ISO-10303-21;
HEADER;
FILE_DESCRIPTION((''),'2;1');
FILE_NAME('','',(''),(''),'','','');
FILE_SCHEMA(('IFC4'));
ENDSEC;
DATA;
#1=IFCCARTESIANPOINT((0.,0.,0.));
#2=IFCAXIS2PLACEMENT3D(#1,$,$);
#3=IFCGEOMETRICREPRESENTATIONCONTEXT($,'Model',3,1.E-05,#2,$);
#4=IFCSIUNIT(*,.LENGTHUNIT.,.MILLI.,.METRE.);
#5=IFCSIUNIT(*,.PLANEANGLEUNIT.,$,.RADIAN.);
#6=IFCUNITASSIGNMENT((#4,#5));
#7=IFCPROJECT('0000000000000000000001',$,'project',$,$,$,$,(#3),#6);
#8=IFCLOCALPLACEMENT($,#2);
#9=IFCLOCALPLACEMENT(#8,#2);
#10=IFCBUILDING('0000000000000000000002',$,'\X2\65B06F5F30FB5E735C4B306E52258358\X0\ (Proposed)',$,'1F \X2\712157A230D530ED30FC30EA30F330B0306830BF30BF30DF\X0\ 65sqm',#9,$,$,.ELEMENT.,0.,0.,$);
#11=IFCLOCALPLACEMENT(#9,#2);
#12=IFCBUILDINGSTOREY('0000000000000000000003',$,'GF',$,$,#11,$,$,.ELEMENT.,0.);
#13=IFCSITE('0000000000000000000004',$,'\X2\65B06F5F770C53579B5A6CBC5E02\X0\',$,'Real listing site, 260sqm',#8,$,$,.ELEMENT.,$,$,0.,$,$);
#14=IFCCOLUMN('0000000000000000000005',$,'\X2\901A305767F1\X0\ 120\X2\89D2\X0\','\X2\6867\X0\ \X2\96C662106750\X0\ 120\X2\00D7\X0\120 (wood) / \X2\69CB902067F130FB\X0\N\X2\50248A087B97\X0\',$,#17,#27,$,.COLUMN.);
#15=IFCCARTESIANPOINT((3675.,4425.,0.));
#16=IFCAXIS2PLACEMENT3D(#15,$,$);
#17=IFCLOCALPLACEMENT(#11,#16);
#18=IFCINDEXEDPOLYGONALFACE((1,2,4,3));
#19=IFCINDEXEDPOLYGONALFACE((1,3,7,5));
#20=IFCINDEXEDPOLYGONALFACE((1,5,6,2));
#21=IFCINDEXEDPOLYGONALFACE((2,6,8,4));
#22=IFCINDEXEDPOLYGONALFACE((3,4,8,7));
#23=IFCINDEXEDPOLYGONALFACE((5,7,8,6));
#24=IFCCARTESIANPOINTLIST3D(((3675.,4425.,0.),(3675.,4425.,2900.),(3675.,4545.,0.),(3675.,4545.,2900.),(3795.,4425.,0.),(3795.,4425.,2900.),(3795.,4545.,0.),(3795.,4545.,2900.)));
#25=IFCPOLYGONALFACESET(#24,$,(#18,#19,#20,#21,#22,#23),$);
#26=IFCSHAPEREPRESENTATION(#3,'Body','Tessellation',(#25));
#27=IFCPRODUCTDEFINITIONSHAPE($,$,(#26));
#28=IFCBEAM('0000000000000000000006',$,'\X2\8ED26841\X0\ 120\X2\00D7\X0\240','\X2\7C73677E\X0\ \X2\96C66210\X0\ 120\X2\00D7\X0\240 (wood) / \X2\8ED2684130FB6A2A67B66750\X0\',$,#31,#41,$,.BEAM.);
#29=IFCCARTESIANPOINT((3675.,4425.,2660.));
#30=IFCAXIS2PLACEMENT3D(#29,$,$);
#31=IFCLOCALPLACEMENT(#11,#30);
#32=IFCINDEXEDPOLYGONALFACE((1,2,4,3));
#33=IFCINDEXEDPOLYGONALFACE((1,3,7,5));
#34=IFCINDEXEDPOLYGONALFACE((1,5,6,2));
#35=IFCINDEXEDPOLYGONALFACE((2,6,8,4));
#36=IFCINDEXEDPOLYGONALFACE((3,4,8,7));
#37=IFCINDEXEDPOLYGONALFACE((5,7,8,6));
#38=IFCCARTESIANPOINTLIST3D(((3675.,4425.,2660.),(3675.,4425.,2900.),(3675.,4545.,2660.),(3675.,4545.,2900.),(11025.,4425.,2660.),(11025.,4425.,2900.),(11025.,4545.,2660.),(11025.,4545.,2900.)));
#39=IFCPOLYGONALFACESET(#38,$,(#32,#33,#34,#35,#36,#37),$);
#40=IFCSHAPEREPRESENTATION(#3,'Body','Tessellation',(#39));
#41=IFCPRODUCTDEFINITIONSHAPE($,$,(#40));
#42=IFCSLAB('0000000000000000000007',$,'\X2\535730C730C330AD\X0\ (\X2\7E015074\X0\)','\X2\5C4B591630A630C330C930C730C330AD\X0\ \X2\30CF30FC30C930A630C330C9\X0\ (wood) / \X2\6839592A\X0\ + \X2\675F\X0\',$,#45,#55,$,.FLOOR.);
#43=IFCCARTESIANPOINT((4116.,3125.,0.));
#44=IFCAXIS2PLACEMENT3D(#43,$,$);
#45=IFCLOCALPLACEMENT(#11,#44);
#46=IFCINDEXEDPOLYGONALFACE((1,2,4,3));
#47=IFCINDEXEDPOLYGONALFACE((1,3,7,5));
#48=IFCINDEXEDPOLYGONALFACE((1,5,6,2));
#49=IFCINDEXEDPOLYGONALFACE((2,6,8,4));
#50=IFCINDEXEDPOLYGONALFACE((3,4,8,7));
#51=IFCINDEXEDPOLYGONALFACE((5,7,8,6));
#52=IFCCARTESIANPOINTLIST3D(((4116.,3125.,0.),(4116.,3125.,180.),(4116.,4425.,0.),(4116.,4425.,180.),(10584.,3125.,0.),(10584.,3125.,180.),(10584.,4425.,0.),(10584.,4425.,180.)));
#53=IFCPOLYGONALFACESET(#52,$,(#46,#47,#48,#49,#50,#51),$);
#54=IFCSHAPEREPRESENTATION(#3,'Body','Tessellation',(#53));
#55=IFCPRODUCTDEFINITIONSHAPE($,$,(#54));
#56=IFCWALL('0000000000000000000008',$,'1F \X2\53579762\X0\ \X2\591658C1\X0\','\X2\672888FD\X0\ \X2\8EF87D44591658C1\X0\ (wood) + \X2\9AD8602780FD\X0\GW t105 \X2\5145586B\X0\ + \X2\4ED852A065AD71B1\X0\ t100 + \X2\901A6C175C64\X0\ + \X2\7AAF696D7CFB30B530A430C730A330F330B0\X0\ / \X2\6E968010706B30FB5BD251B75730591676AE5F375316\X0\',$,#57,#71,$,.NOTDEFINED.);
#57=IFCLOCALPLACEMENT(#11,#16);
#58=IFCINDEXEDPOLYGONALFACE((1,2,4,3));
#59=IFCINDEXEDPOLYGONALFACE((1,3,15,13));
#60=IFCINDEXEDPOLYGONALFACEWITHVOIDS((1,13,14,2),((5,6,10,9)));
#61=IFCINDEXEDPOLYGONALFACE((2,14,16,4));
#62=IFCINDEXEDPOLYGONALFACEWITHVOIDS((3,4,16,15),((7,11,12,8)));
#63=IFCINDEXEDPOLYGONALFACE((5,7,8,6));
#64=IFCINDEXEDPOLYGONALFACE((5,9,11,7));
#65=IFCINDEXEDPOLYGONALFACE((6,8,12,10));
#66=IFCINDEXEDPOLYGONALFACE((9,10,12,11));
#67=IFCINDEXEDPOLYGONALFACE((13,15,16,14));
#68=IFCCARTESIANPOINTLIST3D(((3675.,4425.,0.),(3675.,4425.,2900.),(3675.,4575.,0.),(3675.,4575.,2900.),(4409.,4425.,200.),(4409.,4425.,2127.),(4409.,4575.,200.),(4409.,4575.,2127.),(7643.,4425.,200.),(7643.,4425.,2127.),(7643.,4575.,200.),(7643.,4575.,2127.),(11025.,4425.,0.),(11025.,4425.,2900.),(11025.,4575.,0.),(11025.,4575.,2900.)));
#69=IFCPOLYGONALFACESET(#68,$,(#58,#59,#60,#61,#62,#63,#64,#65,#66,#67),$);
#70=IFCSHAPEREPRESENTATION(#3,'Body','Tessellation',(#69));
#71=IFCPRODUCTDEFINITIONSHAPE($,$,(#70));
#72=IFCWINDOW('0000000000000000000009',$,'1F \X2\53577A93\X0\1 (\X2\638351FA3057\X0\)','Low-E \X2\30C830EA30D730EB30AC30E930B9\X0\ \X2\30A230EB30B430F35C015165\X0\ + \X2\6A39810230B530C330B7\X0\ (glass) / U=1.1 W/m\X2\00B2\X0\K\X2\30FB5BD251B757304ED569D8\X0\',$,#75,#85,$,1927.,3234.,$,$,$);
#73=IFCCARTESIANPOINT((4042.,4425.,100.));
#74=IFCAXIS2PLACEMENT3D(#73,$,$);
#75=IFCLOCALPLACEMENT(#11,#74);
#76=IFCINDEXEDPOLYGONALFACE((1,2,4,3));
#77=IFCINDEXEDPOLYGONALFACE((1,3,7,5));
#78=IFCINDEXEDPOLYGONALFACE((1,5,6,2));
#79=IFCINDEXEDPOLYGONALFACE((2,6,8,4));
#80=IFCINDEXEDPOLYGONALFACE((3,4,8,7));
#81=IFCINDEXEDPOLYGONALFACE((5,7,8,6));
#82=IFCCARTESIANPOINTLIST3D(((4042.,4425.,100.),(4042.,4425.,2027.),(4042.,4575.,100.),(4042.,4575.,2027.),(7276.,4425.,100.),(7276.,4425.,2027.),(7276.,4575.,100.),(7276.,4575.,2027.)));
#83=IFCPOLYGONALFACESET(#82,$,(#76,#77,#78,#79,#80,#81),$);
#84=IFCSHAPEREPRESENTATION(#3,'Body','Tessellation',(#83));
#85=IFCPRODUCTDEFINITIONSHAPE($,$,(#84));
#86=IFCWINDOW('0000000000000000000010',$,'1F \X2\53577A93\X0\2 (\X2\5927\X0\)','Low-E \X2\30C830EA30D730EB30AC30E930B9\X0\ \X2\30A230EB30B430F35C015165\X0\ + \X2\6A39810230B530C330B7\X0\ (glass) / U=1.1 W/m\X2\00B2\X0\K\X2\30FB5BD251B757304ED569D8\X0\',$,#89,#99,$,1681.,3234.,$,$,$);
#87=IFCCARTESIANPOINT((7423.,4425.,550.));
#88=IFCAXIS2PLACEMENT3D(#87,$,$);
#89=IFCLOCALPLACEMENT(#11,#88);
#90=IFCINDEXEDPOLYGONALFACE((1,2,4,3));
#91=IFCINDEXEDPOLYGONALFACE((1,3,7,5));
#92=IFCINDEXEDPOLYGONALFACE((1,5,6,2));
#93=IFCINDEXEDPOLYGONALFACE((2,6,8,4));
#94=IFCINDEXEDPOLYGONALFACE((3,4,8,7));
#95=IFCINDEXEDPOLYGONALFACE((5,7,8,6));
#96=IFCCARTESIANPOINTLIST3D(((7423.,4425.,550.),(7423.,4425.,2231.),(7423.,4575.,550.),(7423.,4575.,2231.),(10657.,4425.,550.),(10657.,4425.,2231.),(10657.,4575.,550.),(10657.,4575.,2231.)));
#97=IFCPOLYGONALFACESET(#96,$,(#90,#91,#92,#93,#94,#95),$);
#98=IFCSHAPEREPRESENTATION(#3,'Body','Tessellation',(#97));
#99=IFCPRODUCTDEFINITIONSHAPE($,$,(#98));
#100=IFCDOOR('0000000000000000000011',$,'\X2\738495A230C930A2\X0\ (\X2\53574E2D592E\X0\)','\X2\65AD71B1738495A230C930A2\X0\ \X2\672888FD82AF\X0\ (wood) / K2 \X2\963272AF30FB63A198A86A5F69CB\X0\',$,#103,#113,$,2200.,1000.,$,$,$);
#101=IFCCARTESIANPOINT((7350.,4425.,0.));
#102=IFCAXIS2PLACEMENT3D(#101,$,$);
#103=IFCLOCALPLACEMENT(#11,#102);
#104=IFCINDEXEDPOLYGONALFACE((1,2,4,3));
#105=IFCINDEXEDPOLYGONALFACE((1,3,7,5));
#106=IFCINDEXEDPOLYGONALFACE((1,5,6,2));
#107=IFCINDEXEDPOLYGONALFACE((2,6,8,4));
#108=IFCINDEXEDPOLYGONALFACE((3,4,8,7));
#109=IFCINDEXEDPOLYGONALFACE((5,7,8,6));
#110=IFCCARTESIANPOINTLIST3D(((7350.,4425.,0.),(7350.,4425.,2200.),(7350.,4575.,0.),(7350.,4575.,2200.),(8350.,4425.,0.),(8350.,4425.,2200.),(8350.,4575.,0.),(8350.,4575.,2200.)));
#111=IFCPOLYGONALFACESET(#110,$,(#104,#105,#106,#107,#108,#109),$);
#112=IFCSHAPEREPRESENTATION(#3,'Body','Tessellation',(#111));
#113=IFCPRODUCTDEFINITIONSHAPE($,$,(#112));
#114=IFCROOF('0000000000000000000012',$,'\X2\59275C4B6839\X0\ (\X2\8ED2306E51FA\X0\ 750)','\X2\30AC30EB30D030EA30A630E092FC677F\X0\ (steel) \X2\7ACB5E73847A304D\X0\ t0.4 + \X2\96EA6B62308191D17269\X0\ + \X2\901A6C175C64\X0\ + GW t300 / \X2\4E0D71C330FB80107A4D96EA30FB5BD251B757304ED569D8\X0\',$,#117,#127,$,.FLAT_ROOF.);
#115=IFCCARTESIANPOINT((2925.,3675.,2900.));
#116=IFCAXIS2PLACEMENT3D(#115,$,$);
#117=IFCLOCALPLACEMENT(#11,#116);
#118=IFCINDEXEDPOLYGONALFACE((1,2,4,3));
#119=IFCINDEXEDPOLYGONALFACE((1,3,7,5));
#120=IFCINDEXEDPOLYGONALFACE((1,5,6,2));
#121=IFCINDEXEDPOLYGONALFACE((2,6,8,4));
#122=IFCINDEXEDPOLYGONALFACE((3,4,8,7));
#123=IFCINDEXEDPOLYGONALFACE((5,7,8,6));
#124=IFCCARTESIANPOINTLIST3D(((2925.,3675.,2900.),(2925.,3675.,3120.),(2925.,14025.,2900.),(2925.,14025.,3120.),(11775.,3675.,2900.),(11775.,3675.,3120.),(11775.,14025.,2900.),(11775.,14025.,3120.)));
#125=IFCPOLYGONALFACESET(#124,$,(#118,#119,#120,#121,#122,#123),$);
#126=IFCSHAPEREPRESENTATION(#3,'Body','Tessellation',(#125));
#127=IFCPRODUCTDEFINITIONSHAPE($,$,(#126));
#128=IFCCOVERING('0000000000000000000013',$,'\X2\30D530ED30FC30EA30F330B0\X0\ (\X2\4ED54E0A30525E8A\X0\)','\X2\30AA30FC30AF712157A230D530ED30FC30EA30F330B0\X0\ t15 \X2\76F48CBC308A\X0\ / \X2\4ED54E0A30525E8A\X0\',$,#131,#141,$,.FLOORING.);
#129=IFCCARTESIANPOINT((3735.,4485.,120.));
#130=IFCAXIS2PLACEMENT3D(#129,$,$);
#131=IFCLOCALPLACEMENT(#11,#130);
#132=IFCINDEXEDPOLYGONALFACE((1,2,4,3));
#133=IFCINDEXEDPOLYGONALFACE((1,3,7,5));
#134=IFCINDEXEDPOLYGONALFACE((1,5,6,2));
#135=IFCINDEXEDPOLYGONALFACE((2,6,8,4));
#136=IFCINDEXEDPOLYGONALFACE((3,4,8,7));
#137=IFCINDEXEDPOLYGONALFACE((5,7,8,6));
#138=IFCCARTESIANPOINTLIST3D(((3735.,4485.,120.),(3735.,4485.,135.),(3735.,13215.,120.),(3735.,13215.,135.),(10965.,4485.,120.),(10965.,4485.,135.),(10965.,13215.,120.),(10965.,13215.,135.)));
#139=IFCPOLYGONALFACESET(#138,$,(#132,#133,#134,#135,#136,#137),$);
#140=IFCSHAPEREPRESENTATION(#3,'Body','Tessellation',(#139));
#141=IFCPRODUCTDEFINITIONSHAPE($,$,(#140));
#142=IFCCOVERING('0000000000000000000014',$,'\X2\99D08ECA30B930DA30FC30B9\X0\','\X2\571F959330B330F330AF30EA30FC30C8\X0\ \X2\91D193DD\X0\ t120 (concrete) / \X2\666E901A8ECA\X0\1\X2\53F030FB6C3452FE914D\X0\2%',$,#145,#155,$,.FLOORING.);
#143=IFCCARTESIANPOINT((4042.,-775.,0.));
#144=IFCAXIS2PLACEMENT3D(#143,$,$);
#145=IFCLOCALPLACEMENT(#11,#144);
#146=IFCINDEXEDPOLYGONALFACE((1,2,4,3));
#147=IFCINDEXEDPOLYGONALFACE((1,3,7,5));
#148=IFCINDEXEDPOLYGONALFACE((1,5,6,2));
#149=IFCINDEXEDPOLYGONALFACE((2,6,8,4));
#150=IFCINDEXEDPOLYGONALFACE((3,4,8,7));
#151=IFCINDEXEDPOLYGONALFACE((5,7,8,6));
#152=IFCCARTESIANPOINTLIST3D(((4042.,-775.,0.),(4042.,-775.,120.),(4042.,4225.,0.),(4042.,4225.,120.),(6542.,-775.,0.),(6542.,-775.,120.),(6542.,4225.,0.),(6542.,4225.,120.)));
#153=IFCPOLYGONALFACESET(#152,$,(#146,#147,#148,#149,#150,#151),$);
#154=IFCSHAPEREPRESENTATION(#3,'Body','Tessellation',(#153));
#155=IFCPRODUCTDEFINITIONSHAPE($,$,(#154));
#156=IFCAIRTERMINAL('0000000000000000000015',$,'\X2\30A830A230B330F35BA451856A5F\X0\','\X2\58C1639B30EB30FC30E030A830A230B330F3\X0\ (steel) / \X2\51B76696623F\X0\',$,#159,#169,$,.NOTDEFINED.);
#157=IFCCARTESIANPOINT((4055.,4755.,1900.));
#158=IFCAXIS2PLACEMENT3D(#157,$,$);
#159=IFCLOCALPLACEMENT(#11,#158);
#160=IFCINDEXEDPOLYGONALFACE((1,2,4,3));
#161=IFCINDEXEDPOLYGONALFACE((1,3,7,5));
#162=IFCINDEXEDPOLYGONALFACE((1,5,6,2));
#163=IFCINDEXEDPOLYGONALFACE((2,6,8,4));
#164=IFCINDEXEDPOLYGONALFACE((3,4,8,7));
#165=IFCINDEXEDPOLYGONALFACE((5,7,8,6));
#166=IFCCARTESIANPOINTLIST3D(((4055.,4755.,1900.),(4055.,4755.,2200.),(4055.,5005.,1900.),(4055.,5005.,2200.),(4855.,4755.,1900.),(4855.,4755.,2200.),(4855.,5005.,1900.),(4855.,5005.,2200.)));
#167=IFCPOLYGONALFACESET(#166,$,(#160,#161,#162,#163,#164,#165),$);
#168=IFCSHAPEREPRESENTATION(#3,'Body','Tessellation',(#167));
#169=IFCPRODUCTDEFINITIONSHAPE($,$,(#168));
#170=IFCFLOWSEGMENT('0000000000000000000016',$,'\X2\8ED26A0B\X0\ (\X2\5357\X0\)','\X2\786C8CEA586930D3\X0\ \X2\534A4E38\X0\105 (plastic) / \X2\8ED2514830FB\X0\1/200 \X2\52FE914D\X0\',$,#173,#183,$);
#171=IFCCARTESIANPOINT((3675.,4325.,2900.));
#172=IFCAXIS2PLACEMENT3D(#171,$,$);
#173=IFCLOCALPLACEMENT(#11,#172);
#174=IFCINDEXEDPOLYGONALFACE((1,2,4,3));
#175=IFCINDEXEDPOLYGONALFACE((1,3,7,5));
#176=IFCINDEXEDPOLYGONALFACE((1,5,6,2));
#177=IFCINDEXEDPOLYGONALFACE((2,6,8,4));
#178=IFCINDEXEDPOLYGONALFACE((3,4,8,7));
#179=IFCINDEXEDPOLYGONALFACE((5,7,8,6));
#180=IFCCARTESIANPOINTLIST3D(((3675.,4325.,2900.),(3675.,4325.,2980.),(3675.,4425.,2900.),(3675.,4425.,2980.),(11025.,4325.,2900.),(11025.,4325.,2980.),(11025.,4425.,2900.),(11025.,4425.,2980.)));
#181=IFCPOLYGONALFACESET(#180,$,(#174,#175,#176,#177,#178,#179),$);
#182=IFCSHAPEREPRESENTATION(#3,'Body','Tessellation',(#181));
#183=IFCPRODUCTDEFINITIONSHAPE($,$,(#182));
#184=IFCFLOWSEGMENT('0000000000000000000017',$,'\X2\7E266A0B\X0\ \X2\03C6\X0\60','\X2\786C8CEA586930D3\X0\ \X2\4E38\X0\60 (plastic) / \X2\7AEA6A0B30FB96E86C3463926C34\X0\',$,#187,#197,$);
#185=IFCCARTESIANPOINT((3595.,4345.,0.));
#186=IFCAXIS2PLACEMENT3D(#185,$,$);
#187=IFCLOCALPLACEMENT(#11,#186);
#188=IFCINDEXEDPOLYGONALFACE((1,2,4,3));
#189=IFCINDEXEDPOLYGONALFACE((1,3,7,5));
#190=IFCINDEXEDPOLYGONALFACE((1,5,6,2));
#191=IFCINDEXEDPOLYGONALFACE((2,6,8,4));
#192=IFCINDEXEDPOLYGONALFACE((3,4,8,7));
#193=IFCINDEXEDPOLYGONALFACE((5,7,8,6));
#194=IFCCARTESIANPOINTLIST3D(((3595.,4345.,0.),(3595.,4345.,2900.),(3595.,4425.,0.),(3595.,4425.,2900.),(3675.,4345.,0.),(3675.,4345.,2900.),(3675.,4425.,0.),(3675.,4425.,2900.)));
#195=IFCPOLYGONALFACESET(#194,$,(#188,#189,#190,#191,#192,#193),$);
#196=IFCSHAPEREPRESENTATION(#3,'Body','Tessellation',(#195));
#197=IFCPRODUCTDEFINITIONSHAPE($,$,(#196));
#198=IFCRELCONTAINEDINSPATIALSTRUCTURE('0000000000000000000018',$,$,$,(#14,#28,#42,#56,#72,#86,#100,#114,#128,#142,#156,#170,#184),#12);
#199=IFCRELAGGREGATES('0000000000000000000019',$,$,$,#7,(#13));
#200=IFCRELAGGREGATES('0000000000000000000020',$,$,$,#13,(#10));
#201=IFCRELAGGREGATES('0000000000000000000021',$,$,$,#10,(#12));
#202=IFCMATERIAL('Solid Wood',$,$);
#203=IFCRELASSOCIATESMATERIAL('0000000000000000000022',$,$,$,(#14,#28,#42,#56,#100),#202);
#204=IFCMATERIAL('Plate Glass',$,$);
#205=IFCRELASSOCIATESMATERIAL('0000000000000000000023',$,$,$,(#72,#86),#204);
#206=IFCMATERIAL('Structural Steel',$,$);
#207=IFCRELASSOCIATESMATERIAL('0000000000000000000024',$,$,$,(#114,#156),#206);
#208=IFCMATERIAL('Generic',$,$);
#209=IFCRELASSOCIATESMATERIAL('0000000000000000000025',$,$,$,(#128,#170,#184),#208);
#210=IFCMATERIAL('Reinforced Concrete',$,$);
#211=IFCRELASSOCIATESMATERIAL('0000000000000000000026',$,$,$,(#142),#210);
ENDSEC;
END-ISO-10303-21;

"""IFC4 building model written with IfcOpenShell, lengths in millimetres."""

from ifc_helpers import new_model, si_unit, frame, frame_2d, origin, place, context, project, spatial, rectangle, extrude, material, element, fill, save


model = new_model("IFC4")

# Units and contexts
model_context = context("Model", 3, precision=1e-05, world=origin())
ifc_project = project(units=[si_unit("LENGTHUNIT", "METRE", prefix="MILLI"), si_unit("PLANEANGLEUNIT", "RADIAN")], contexts=[model_context])

# Site, building, storey
site_placement = place(None, origin())
site = spatial("IfcSite", under=ifc_project, at=site_placement, Name="新潟県南魚沼市", ObjectType="Real listing site, 260sqm", CompositionType="ELEMENT", RefElevation=0.0)
building_placement = place(site_placement, origin())
building = spatial("IfcBuilding", under=site, at=building_placement, Name="新潟・平屋の別荘 (Proposed)", ObjectType="1F 無垢フローリングとタタミ 65sqm", CompositionType="ELEMENT", ElevationOfRefHeight=0.0, ElevationOfTerrain=0.0)
storey_placement = place(building_placement, origin())
storey = spatial("IfcBuildingStorey", under=building, at=storey_placement, Name="GF", CompositionType="ELEMENT", Elevation=0.0)

# Column
ifc_material_1 = material(Name="Solid Wood")
column_1_placement = place(storey_placement, frame((3675.0, 4425.0, 0.0)))
element("IfcColumn", 1, at=column_1_placement, inside=storey, material=ifc_material_1, Name="通し柱 120角", Description="桧 集成材 120×120 (wood) / 構造柱・N値計算", PredefinedType="COLUMN", context=model_context, shape_type="SweptSolid", body=[
    extrude(rectangle(XDim=120.0, YDim=120.0, at=frame_2d((60.0, 60.0))), frame((3675.0, 4425.0, 0.0)), (0.0, 0.0, 1.0), 2900.0),
])

# Beam
beam_1_placement = place(storey_placement, frame((3675.0, 4425.0, 2660.0)))
element("IfcBeam", 2, at=beam_1_placement, inside=storey, material=ifc_material_1, Name="軒桁 120×240", Description="米松 集成 120×240 (wood) / 軒桁・横架材", PredefinedType="BEAM", context=model_context, shape_type="SweptSolid", body=[
    extrude(rectangle(XDim=7350.0, YDim=120.0, at=frame_2d((3675.0, 60.0))), frame((3675.0, 4425.0, 2660.0)), (0.0, 0.0, 1.0), 240.0),
])

# Slab
ifc_material_2 = material(Name="Reinforced Concrete")
slab_1_placement = place(storey_placement, frame((4116.0, 3125.0, 0.0)))
element("IfcSlab", 3, at=slab_1_placement, inside=storey, material=ifc_material_1, Name="南デッキ (縁側)", Description="屋外ウッドデッキ ハードウッド (wood) / 根太 + 束", PredefinedType="FLOOR", context=model_context, shape_type="SweptSolid", body=[
    extrude(rectangle(XDim=6468.0, YDim=1300.0, at=frame_2d((3234.0, 650.0))), frame((4116.0, 3125.0, 0.0)), (0.0, 0.0, 1.0), 180.0),
])

# Wall, openings, windows, door
wall_1_placement = place(storey_placement, frame((3675.0, 4425.0, 0.0)))
wall_1 = element("IfcWall", 4, at=wall_1_placement, inside=storey, material=ifc_material_1, Name="1F 南面 外壁", Description="木製 軸組外壁 (wood) + 高性能GW t105 充填 + 付加断熱 t100 + 通気層 + 窯業系サイディング / 準耐火・寒冷地外皮強化", PredefinedType="NOTDEFINED", context=model_context, shape_type="SweptSolid", body=[
    extrude(rectangle(XDim=7350.0, YDim=150.0, at=frame_2d((3675.0, 75.0))), frame((3675.0, 4425.0, 0.0)), (0.0, 0.0, 1.0), 2900.0),
])
opening_1_placement = place(storey_placement, frame((4042.0, 4425.0, 100.0)))
opening_1 = element("IfcOpeningElement", 5, at=opening_1_placement, cuts=wall_1, PredefinedType="NOTDEFINED", context=model_context, shape_type="SweptSolid", body=[
    extrude(rectangle(XDim=3234.0, YDim=150.0, at=frame_2d((1617.0, 75.0))), frame((4042.0, 4425.0, 100.0)), (0.0, 0.0, 1.0), 1927.0),
])
opening_2_placement = place(storey_placement, frame((7423.0, 4425.0, 550.0)))
opening_2 = element("IfcOpeningElement", 6, at=opening_2_placement, cuts=wall_1, PredefinedType="NOTDEFINED", context=model_context, shape_type="SweptSolid", body=[
    extrude(rectangle(XDim=3234.0, YDim=150.0, at=frame_2d((1617.0, 75.0))), frame((7423.0, 4425.0, 550.0)), (0.0, 0.0, 1.0), 1681.0),
])
opening_3_placement = place(storey_placement, frame((7350.0, 4425.0, 0.0)))
opening_3 = element("IfcOpeningElement", 7, at=opening_3_placement, cuts=wall_1, PredefinedType="NOTDEFINED", context=model_context, shape_type="SweptSolid", body=[
    extrude(rectangle(XDim=1000.0, YDim=150.0, at=frame_2d((500.0, 75.0))), frame((7350.0, 4425.0, 0.0)), (0.0, 0.0, 1.0), 2200.0),
])
ifc_material_3 = material(Name="Plate Glass")
window_1_placement = place(storey_placement, frame((4042.0, 4425.0, 100.0)))
window_1 = element("IfcWindow", 8, at=window_1_placement, inside=storey, material=ifc_material_3, Name="1F 南窓1 (掃出し)", Description="Low-E トリプルガラス アルゴン封入 + 樹脂サッシ (glass) / U=1.1 W/m²K・寒冷地仕様", OverallHeight=1927.0, OverallWidth=3234.0, context=model_context, shape_type="SweptSolid", body=[
    extrude(rectangle(XDim=3234.0, YDim=150.0, at=frame_2d((1617.0, 75.0))), frame((4042.0, 4425.0, 100.0)), (0.0, 0.0, 1.0), 1927.0),
])
fill(opening_1, window_1)
window_2_placement = place(storey_placement, frame((7423.0, 4425.0, 550.0)))
window_2 = element("IfcWindow", 9, at=window_2_placement, inside=storey, material=ifc_material_3, Name="1F 南窓2 (大)", Description="Low-E トリプルガラス アルゴン封入 + 樹脂サッシ (glass) / U=1.1 W/m²K・寒冷地仕様", OverallHeight=1681.0, OverallWidth=3234.0, context=model_context, shape_type="SweptSolid", body=[
    extrude(rectangle(XDim=3234.0, YDim=150.0, at=frame_2d((1617.0, 75.0))), frame((7423.0, 4425.0, 550.0)), (0.0, 0.0, 1.0), 1681.0),
])
fill(opening_2, window_2)
door_placement = place(storey_placement, frame((7350.0, 4425.0, 0.0)))
door = element("IfcDoor", 10, at=door_placement, inside=storey, material=ifc_material_1, Name="玄関ドア (南中央)", Description="断熱玄関ドア 木製芯 (wood) / K2 防犯・採風機構", OverallHeight=2200.0, OverallWidth=1000.0, context=model_context, shape_type="SweptSolid", body=[
    extrude(rectangle(XDim=1000.0, YDim=150.0, at=frame_2d((500.0, 75.0))), frame((7350.0, 4425.0, 0.0)), (0.0, 0.0, 1.0), 2200.0),
])
fill(opening_3, door)

# Roof
ifc_material_4 = material(Name="Structural Steel")
roof_placement = place(storey_placement, frame((2925.0, 3675.0, 2900.0)))
element("IfcRoof", 11, at=roof_placement, inside=storey, material=ifc_material_4, Name="大屋根 (軒の出 750)", Description="ガルバリウム鋼板 (steel) 立平葺き t0.4 + 雪止め金物 + 通気層 + GW t300 / 不燃・耐積雪・寒冷地仕様", PredefinedType="FLAT_ROOF", context=model_context, shape_type="SweptSolid", body=[
    extrude(rectangle(XDim=8850.0, YDim=10350.0, at=frame_2d((4425.0, 5175.0))), frame((2925.0, 3675.0, 2900.0)), (0.0, 0.0, 1.0), 220.0),
])

# Coverings
ifc_material_5 = material(Name="Generic")
covering_1_placement = place(storey_placement, frame((3735.0, 4485.0, 120.0)))
element("IfcCovering", 12, at=covering_1_placement, inside=storey, material=ifc_material_5, Name="フローリング (仕上げ床)", Description="オーク無垢フローリング t15 直貼り / 仕上げ床", PredefinedType="FLOORING", context=model_context, shape_type="SweptSolid", body=[
    extrude(rectangle(XDim=7230.0, YDim=8730.0, at=frame_2d((3615.0, 4365.0))), frame((3735.0, 4485.0, 120.0)), (0.0, 0.0, 1.0), 15.0),
])
covering_2_placement = place(storey_placement, frame((4042.0, -775.0, 0.0)))
element("IfcCovering", 13, at=covering_2_placement, inside=storey, material=ifc_material_2, Name="駐車スペース", Description="土間コンクリート 金鏝 t120 (concrete) / 普通車1台・水勾配2%", PredefinedType="FLOORING", context=model_context, shape_type="SweptSolid", body=[
    extrude(rectangle(XDim=2500.0, YDim=5000.0, at=frame_2d((1250.0, 2500.0))), frame((4042.0, -775.0, 0.0)), (0.0, 0.0, 1.0), 120.0),
])

# Air terminal
air_terminal_placement = place(storey_placement, frame((4055.0, 4755.0, 1900.0)))
element("IfcAirTerminal", 14, at=air_terminal_placement, inside=storey, material=ifc_material_4, Name="エアコン室内機", Description="壁掛ルームエアコン (steel) / 冷暖房", PredefinedType="NOTDEFINED", context=model_context, shape_type="SweptSolid", body=[
    extrude(rectangle(XDim=800.0, YDim=250.0, at=frame_2d((400.0, 125.0))), frame((4055.0, 4755.0, 1900.0)), (0.0, 0.0, 1.0), 300.0),
])

# Flow segments
flow_segment_1_placement = place(storey_placement, frame((3675.0, 4325.0, 2900.0)))
element("IfcFlowSegment", 15, at=flow_segment_1_placement, inside=storey, material=ifc_material_5, Name="軒樋 (南)", Description="硬質塩ビ 半丸105 (plastic) / 軒先・1/200 勾配", context=model_context, shape_type="SweptSolid", body=[
    extrude(rectangle(XDim=7350.0, YDim=100.0, at=frame_2d((3675.0, 50.0))), frame((3675.0, 4325.0, 2900.0)), (0.0, 0.0, 1.0), 80.0),
])
flow_segment_2_placement = place(storey_placement, frame((3595.0, 4345.0, 0.0)))
element("IfcFlowSegment", 16, at=flow_segment_2_placement, inside=storey, material=ifc_material_5, Name="縦樋 φ60", Description="硬質塩ビ 丸60 (plastic) / 竪樋・雨水排水", context=model_context, shape_type="SweptSolid", body=[
    extrude(rectangle(XDim=80.0, YDim=80.0, at=frame_2d((40.0, 40.0))), frame((3595.0, 4345.0, 0.0)), (0.0, 0.0, 1.0), 2900.0),
])

save(model, "model.ifc")
